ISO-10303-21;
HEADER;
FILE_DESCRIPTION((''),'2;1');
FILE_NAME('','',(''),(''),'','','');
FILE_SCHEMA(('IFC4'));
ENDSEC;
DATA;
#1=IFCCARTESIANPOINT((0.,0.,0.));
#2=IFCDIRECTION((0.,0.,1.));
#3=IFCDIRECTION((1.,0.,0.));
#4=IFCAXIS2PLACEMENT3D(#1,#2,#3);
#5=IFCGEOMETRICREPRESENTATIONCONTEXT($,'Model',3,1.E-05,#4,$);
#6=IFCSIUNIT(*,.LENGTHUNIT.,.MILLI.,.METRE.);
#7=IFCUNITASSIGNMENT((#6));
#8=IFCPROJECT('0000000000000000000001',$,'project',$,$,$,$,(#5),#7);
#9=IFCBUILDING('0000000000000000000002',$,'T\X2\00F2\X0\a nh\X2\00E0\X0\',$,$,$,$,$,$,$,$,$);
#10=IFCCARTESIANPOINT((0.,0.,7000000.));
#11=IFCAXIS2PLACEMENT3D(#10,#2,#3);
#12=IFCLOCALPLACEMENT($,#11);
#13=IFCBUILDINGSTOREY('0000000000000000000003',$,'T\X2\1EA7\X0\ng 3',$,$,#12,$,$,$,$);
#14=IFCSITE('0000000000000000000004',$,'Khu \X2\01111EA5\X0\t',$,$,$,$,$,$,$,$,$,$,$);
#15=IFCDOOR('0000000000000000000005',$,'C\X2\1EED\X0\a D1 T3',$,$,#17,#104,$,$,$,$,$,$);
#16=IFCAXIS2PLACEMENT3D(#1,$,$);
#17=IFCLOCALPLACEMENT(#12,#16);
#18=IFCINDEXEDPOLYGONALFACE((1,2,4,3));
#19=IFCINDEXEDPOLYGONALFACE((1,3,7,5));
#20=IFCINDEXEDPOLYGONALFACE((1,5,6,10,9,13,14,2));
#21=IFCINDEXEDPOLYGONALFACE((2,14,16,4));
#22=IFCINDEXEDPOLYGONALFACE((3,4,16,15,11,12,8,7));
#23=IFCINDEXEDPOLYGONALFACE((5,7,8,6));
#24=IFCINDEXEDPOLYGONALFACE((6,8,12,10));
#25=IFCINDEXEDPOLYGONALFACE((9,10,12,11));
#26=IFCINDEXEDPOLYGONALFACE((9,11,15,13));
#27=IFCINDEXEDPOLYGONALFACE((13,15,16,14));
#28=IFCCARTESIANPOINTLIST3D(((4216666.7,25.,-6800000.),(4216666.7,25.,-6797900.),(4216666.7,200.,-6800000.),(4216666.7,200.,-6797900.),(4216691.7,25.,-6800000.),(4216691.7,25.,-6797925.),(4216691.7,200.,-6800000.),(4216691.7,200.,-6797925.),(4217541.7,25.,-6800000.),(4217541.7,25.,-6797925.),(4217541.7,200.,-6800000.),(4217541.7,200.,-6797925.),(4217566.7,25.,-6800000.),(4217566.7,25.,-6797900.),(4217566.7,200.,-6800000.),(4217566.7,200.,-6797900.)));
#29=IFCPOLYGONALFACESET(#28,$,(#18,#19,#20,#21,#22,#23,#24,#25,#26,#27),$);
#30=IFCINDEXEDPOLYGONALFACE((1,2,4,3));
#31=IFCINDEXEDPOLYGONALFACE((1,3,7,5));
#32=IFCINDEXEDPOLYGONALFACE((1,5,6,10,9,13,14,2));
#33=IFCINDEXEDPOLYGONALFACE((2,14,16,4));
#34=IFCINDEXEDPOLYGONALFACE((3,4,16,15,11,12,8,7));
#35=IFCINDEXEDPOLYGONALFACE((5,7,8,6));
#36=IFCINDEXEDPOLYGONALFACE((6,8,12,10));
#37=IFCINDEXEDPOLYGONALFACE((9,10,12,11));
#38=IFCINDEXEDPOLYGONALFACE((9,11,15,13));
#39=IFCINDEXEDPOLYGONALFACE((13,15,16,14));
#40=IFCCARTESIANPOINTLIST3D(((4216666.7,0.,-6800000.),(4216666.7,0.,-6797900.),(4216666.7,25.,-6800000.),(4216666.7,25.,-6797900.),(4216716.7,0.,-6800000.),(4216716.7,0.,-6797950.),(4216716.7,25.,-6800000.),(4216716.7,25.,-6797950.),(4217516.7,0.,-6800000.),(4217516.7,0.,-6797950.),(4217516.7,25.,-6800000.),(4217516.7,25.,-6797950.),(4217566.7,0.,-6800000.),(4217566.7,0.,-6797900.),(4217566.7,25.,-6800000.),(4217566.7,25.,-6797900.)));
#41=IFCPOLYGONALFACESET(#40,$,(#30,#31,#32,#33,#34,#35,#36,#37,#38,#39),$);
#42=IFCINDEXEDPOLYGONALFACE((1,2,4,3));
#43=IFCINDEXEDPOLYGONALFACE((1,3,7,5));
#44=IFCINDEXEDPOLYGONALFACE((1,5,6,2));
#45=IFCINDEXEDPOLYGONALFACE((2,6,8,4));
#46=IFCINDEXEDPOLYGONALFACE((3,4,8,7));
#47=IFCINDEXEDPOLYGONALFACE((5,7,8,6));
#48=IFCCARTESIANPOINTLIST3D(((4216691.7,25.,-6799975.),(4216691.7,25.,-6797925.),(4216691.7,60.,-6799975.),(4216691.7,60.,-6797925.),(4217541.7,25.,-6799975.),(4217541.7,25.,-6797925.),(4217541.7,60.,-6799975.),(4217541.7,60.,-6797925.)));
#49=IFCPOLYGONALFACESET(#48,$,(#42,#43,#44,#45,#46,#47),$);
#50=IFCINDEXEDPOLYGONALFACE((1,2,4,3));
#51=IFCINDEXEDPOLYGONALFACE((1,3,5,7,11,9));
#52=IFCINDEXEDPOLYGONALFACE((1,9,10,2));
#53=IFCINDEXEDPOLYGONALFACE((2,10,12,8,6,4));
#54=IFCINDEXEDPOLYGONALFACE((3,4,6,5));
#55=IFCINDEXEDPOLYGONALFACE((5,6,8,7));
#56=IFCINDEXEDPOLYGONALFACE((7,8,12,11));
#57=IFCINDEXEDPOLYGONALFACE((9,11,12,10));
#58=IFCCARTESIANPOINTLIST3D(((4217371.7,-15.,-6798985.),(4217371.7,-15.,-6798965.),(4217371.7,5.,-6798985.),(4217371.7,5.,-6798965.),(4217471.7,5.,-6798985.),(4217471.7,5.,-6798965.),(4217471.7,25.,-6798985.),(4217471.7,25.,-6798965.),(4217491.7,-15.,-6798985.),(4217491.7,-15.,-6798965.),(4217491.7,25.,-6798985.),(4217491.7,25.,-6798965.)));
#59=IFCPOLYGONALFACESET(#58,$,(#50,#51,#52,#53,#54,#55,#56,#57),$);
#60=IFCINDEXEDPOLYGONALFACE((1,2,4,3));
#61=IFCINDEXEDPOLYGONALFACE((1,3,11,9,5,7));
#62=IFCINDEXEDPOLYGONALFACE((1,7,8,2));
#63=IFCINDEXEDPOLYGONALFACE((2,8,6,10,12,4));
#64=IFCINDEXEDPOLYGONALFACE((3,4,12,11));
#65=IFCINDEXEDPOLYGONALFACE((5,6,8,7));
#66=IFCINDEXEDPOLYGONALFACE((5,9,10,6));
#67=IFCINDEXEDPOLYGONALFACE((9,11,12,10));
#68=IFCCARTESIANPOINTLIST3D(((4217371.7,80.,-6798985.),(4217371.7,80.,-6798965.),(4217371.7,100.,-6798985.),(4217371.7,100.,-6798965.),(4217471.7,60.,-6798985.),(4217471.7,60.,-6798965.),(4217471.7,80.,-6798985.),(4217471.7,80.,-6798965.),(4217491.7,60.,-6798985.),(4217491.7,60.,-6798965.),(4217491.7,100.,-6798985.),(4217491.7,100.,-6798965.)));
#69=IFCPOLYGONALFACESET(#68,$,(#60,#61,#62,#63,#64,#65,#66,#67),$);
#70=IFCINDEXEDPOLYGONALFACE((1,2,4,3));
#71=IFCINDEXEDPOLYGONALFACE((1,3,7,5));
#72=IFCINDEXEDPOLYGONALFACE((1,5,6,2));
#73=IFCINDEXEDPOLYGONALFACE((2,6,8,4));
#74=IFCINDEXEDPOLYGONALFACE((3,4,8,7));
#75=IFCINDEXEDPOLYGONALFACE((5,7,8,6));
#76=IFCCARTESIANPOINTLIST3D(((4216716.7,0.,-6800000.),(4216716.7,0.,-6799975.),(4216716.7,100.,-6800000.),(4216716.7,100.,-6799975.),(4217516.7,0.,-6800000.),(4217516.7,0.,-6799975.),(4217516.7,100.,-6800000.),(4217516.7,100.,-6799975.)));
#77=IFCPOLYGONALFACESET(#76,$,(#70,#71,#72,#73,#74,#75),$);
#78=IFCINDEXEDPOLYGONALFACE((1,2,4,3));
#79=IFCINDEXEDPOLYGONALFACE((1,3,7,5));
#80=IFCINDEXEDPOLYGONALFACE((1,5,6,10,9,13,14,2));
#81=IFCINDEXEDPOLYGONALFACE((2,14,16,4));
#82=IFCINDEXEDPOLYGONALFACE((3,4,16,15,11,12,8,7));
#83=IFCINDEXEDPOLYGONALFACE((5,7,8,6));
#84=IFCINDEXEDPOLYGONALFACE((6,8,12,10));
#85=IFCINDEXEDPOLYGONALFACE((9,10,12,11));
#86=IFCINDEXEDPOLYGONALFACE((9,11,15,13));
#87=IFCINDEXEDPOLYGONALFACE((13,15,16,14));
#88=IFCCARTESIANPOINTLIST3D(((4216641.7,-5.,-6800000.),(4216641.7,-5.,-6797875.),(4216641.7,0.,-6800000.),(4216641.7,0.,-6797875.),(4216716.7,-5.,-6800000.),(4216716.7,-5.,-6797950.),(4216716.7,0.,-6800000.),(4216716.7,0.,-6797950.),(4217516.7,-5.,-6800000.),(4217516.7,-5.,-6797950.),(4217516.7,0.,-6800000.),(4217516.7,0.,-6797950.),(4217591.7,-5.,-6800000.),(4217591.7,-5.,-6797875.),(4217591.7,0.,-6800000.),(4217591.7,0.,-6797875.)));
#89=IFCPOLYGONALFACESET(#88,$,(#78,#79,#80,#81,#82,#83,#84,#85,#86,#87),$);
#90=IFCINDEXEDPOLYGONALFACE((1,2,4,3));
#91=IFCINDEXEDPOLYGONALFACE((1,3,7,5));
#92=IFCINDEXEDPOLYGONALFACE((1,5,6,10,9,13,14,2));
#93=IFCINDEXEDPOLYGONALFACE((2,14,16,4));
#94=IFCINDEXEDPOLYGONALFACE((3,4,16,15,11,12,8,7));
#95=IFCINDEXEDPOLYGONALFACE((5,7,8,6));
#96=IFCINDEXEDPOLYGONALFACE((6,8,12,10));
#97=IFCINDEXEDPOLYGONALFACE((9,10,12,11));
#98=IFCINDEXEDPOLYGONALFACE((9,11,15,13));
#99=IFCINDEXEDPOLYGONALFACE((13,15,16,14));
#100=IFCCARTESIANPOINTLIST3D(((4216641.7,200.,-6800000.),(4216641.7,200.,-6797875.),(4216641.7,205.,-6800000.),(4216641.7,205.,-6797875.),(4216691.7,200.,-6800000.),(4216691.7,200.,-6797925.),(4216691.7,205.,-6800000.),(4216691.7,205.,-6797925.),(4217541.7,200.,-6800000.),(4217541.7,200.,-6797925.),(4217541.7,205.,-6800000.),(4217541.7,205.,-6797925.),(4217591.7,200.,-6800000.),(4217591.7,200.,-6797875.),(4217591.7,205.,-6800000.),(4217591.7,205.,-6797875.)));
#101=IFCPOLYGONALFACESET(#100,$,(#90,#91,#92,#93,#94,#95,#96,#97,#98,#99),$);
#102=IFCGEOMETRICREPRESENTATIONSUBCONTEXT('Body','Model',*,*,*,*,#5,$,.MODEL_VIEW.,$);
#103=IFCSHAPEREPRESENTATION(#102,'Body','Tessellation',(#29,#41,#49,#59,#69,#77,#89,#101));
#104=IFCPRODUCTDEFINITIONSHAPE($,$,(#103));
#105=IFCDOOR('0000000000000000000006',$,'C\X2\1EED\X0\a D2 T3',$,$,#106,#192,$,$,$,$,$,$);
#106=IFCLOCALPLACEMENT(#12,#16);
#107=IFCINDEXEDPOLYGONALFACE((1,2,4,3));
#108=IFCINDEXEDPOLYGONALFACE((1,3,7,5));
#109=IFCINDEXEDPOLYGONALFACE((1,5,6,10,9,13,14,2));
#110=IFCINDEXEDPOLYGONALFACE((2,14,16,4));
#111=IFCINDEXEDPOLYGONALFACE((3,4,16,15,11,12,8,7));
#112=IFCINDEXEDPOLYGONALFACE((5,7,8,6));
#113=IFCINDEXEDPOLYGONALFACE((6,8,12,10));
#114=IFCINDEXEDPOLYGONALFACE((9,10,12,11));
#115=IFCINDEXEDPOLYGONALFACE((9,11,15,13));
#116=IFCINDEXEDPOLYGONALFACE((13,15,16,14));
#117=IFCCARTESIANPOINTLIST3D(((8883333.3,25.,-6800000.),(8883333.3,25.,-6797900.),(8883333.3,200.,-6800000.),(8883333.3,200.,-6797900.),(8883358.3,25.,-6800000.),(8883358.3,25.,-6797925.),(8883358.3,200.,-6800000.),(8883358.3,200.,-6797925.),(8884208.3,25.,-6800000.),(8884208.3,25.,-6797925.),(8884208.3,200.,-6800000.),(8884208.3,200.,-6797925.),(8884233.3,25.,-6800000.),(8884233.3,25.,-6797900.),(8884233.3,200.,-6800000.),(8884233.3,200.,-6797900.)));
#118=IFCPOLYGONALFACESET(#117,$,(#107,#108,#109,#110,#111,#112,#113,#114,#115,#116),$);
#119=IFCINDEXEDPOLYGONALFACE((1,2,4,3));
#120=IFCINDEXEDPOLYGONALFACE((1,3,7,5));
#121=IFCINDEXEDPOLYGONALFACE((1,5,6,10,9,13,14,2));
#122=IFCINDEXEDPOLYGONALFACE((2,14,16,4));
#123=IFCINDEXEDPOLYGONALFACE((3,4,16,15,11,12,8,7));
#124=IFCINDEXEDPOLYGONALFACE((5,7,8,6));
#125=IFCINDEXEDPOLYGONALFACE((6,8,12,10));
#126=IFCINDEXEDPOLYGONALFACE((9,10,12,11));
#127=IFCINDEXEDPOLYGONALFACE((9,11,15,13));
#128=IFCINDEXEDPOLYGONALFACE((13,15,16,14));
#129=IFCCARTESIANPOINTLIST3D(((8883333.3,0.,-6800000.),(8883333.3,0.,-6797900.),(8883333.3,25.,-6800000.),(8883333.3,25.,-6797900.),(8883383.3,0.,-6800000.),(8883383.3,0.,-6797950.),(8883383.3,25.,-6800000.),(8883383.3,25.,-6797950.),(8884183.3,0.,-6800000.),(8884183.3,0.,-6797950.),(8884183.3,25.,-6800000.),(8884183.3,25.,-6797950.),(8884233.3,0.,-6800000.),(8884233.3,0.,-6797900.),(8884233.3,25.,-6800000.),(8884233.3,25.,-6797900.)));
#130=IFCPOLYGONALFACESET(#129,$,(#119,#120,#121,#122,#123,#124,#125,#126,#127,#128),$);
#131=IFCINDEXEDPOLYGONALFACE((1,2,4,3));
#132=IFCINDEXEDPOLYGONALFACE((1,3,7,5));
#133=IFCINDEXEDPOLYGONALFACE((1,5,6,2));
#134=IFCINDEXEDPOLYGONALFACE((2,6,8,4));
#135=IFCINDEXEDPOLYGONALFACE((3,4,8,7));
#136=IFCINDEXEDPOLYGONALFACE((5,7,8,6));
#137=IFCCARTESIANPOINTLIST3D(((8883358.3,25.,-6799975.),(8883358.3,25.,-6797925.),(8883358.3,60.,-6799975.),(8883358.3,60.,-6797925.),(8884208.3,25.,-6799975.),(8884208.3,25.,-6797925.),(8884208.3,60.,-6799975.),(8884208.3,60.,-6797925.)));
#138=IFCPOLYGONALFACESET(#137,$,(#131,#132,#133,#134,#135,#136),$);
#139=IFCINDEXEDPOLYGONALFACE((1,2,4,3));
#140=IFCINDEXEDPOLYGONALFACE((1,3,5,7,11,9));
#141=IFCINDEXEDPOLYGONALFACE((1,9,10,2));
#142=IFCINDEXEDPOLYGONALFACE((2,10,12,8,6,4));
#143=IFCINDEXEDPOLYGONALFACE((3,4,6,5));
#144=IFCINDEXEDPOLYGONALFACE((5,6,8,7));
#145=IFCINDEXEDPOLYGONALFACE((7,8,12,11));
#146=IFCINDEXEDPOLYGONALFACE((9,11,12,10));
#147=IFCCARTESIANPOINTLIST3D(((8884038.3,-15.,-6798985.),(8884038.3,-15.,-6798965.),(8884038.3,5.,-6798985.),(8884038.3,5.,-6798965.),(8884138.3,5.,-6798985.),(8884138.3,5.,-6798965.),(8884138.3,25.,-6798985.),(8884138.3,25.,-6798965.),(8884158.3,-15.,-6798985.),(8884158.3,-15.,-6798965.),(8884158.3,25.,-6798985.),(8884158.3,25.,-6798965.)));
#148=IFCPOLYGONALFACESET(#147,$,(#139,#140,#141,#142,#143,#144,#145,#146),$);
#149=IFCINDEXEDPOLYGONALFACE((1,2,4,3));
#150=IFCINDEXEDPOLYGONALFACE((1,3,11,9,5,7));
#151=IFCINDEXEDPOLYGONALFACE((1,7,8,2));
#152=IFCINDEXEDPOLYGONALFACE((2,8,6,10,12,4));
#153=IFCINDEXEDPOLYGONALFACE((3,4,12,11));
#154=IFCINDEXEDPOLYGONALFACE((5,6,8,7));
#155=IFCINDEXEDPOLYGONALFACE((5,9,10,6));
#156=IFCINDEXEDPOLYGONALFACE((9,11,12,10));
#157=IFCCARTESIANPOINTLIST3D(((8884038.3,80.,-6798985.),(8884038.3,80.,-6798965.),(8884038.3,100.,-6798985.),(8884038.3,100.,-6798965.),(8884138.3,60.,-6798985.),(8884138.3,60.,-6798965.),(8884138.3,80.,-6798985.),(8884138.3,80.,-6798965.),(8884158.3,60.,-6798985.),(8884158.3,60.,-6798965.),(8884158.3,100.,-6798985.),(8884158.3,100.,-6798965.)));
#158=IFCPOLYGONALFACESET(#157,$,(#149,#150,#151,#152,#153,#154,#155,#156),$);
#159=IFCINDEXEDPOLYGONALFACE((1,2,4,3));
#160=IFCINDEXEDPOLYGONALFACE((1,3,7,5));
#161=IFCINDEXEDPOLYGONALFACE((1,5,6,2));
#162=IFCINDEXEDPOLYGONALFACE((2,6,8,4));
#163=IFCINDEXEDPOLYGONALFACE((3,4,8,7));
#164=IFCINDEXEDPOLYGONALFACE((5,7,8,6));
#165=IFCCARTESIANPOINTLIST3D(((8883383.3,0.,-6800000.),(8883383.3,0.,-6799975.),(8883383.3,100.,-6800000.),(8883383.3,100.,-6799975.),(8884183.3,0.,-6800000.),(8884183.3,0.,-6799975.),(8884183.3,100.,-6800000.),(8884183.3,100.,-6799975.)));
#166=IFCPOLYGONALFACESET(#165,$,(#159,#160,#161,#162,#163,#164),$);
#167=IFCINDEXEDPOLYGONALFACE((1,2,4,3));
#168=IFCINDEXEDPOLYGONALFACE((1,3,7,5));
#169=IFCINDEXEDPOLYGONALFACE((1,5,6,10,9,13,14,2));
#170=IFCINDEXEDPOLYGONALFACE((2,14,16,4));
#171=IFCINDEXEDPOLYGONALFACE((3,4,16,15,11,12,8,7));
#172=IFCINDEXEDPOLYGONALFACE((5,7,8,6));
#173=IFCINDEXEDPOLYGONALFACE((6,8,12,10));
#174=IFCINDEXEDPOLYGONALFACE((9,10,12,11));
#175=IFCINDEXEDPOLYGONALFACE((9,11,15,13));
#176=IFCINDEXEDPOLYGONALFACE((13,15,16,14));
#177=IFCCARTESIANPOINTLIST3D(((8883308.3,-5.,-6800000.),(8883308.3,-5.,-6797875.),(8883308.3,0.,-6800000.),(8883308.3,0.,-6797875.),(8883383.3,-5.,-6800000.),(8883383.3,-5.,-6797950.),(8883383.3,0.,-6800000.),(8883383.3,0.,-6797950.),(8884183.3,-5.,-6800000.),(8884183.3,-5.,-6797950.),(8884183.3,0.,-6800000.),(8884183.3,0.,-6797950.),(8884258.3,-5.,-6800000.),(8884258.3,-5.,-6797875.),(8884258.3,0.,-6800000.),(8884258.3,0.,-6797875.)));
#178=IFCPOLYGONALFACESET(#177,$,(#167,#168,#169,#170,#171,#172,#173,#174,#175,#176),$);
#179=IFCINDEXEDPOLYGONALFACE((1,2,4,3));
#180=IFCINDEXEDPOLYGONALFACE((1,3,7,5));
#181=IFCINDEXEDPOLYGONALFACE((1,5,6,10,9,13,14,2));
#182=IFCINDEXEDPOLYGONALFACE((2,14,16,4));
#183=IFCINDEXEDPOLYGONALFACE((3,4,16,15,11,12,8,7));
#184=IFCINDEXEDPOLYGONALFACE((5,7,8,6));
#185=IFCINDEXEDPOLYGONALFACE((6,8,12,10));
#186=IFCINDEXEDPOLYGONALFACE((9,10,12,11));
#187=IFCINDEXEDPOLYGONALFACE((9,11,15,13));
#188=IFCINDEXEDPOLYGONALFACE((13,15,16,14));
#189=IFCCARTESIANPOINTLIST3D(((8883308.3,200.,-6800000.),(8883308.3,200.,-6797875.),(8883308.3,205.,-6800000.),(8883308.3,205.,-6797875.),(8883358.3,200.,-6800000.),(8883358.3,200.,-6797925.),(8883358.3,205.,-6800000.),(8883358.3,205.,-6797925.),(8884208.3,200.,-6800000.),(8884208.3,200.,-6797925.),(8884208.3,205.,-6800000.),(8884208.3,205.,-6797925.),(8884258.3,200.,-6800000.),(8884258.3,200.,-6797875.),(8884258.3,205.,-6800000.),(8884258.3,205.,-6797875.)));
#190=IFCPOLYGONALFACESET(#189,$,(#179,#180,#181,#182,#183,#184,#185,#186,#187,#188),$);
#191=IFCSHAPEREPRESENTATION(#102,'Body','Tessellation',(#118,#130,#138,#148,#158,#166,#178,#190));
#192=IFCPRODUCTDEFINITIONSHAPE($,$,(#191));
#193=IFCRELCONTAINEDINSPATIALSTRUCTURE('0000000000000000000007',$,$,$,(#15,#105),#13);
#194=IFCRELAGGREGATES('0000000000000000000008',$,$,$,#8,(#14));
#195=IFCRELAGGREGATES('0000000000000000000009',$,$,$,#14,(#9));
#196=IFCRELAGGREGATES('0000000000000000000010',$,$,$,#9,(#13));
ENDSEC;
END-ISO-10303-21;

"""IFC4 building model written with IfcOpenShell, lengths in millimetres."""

from ifc_helpers import new_model, si_unit, frame, origin_with_axes, place, context, subcontext, project, spatial, line, indexed_curve, outline, extrude, element, save


model = new_model("IFC4")

# Units and contexts
model_context = context("Model", 3, precision=1e-05, world=origin_with_axes())
body_context = subcontext(model_context, "Body", "Model", "MODEL_VIEW")
ifc_project = project(units=[si_unit("LENGTHUNIT", "METRE", prefix="MILLI")], contexts=[model_context])

# Site, building, storey
site = spatial("IfcSite", under=ifc_project, Name="Khu đất")
building = spatial("IfcBuilding", under=site, Name="Tòa nhà")
storey_placement = place(None, frame((0.0, 0.0, 7000000.0), z_axis=(0.0, 0.0, 1.0), x_axis=(1.0, 0.0, 0.0)))
storey = spatial("IfcBuildingStorey", under=building, at=storey_placement, Name="Tầng 3")

# Doors
door_1_placement = place(storey_placement, frame((4216666.7, 0.0, -6800000.0), z_axis=(0.0, 0.0, 1.0), x_axis=(1.0, 0.0, 0.0)))
element("IfcDoor", 1, at=door_1_placement, inside=storey, Name="Cửa D1 T3", context=body_context, shape_type="SolidModel", body=[
    extrude(outline(indexed_curve([(0.0, 0.0), (0.0, 2100.0), (900.0, 2100.0), (900.0, 0.0), (875.0, 0.0), (875.0, 2075.0), (25.0, 2075.0), (25.0, 0.0)], segments=[line(1, 2, 3, 4, 5, 6, 7, 8, 1)])), frame((0.0, 25.0, 0.0), z_axis=(0.0, -1.0, 0.0), x_axis=(1.0, 0.0, 0.0)), (0.0, 0.0, -1.0), 175.0),
    extrude(outline(indexed_curve([(0.0, 0.0), (0.0, 2100.0), (900.0, 2100.0), (900.0, 0.0), (850.0, 0.0), (850.0, 2050.0), (50.0, 2050.0), (50.0, 0.0)], segments=[line(1, 2, 3, 4, 5, 6, 7, 8, 1)])), frame((0.0, 0.0, 0.0), z_axis=(0.0, -1.0, 0.0), x_axis=(1.0, 0.0, 0.0)), (0.0, 0.0, -1.0), 25.0),
    extrude(outline(indexed_curve([(0.0, 0.0), (850.0, 0.0), (850.0, 35.0), (0.0, 35.0)], segments=[line(1, 2, 3, 4, 1)])), frame((25.0, 25.0, 25.0), z_axis=(0.0, 0.0, 1.0), x_axis=(1.0, 0.0, 0.0)), (0.0, 0.0, 1.0), 2050.0),
    extrude(outline(indexed_curve([(0.0, 0.0), (0.0, -40.0), (-120.0, -40.0), (-120.0, -20.0), (-20.0, -20.0), (-20.0, 0.0)], segments=[line(1, 2, 3, 4, 5, 6, 1)])), frame((825.0, 25.0, 1015.0), z_axis=(0.0, 0.0, 1.0), x_axis=(1.0, 0.0, 0.0)), (0.0, 0.0, 1.0), 20.0),
    extrude(outline(indexed_curve([(0.0, 0.0), (0.0, 40.0), (-120.0, 40.0), (-120.0, 20.0), (-20.0, 20.0), (-20.0, 0.0)], segments=[line(1, 2, 3, 4, 5, 6, 1)])), frame((825.0, 60.0, 1015.0), z_axis=(0.0, 0.0, 1.0), x_axis=(1.0, 0.0, 0.0)), (0.0, 0.0, 1.0), 20.0),
    extrude(outline(indexed_curve([(0.0, 0.0), (800.0, 0.0), (800.0, 100.0), (0.0, 100.0)], segments=[line(1, 2, 3, 4, 1)])), frame((50.0, 0.0, 0.0), z_axis=(0.0, 0.0, 1.0), x_axis=(1.0, 0.0, 0.0)), (0.0, 0.0, 1.0), 25.0),
    extrude(outline(indexed_curve([(0.0, 0.0), (0.0, 2125.0), (950.0, 2125.0), (950.0, 0.0), (875.0, 0.0), (875.0, 2050.0), (75.0, 2050.0), (75.0, 0.0)], segments=[line(1, 2, 3, 4, 5, 6, 7, 8, 1)])), frame((-25.0, -5.0, 0.0), z_axis=(0.0, -1.0, 0.0), x_axis=(1.0, 0.0, 0.0)), (0.0, 0.0, -1.0), 5.0),
    extrude(outline(indexed_curve([(0.0, 0.0), (0.0, 2125.0), (950.0, 2125.0), (950.0, 0.0), (900.0, 0.0), (900.0, 2075.0), (50.0, 2075.0), (50.0, 0.0)], segments=[line(1, 2, 3, 4, 5, 6, 7, 8, 1)])), frame((-25.0, 200.0, 0.0), z_axis=(0.0, -1.0, 0.0), x_axis=(1.0, 0.0, 0.0)), (0.0, 0.0, -1.0), 5.0),
])
door_2_placement = place(storey_placement, frame((8883333.3, 0.0, -6800000.0), z_axis=(0.0, 0.0, 1.0), x_axis=(1.0, 0.0, 0.0)))
element("IfcDoor", 2, at=door_2_placement, inside=storey, Name="Cửa D2 T3", context=body_context, shape_type="SolidModel", body=[
    extrude(outline(indexed_curve([(0.0, 0.0), (0.0, 2100.0), (900.0, 2100.0), (900.0, 0.0), (875.0, 0.0), (875.0, 2075.0), (25.0, 2075.0), (25.0, 0.0)], segments=[line(1, 2, 3, 4, 5, 6, 7, 8, 1)])), frame((0.0, 25.0, 0.0), z_axis=(0.0, -1.0, 0.0), x_axis=(1.0, 0.0, 0.0)), (0.0, 0.0, -1.0), 175.0),
    extrude(outline(indexed_curve([(0.0, 0.0), (0.0, 2100.0), (900.0, 2100.0), (900.0, 0.0), (850.0, 0.0), (850.0, 2050.0), (50.0, 2050.0), (50.0, 0.0)], segments=[line(1, 2, 3, 4, 5, 6, 7, 8, 1)])), frame((0.0, 0.0, 0.0), z_axis=(0.0, -1.0, 0.0), x_axis=(1.0, 0.0, 0.0)), (0.0, 0.0, -1.0), 25.0),
    extrude(outline(indexed_curve([(0.0, 0.0), (850.0, 0.0), (850.0, 35.0), (0.0, 35.0)], segments=[line(1, 2, 3, 4, 1)])), frame((25.0, 25.0, 25.0), z_axis=(0.0, 0.0, 1.0), x_axis=(1.0, 0.0, 0.0)), (0.0, 0.0, 1.0), 2050.0),
    extrude(outline(indexed_curve([(0.0, 0.0), (0.0, -40.0), (-120.0, -40.0), (-120.0, -20.0), (-20.0, -20.0), (-20.0, 0.0)], segments=[line(1, 2, 3, 4, 5, 6, 1)])), frame((825.0, 25.0, 1015.0), z_axis=(0.0, 0.0, 1.0), x_axis=(1.0, 0.0, 0.0)), (0.0, 0.0, 1.0), 20.0),
    extrude(outline(indexed_curve([(0.0, 0.0), (0.0, 40.0), (-120.0, 40.0), (-120.0, 20.0), (-20.0, 20.0), (-20.0, 0.0)], segments=[line(1, 2, 3, 4, 5, 6, 1)])), frame((825.0, 60.0, 1015.0), z_axis=(0.0, 0.0, 1.0), x_axis=(1.0, 0.0, 0.0)), (0.0, 0.0, 1.0), 20.0),
    extrude(outline(indexed_curve([(0.0, 0.0), (800.0, 0.0), (800.0, 100.0), (0.0, 100.0)], segments=[line(1, 2, 3, 4, 1)])), frame((50.0, 0.0, 0.0), z_axis=(0.0, 0.0, 1.0), x_axis=(1.0, 0.0, 0.0)), (0.0, 0.0, 1.0), 25.0),
    extrude(outline(indexed_curve([(0.0, 0.0), (0.0, 2125.0), (950.0, 2125.0), (950.0, 0.0), (875.0, 0.0), (875.0, 2050.0), (75.0, 2050.0), (75.0, 0.0)], segments=[line(1, 2, 3, 4, 5, 6, 7, 8, 1)])), frame((-25.0, -5.0, 0.0), z_axis=(0.0, -1.0, 0.0), x_axis=(1.0, 0.0, 0.0)), (0.0, 0.0, -1.0), 5.0),
    extrude(outline(indexed_curve([(0.0, 0.0), (0.0, 2125.0), (950.0, 2125.0), (950.0, 0.0), (900.0, 0.0), (900.0, 2075.0), (50.0, 2075.0), (50.0, 0.0)], segments=[line(1, 2, 3, 4, 5, 6, 7, 8, 1)])), frame((-25.0, 200.0, 0.0), z_axis=(0.0, -1.0, 0.0), x_axis=(1.0, 0.0, 0.0)), (0.0, 0.0, -1.0), 5.0),
])

save(model, "model.ifc")
